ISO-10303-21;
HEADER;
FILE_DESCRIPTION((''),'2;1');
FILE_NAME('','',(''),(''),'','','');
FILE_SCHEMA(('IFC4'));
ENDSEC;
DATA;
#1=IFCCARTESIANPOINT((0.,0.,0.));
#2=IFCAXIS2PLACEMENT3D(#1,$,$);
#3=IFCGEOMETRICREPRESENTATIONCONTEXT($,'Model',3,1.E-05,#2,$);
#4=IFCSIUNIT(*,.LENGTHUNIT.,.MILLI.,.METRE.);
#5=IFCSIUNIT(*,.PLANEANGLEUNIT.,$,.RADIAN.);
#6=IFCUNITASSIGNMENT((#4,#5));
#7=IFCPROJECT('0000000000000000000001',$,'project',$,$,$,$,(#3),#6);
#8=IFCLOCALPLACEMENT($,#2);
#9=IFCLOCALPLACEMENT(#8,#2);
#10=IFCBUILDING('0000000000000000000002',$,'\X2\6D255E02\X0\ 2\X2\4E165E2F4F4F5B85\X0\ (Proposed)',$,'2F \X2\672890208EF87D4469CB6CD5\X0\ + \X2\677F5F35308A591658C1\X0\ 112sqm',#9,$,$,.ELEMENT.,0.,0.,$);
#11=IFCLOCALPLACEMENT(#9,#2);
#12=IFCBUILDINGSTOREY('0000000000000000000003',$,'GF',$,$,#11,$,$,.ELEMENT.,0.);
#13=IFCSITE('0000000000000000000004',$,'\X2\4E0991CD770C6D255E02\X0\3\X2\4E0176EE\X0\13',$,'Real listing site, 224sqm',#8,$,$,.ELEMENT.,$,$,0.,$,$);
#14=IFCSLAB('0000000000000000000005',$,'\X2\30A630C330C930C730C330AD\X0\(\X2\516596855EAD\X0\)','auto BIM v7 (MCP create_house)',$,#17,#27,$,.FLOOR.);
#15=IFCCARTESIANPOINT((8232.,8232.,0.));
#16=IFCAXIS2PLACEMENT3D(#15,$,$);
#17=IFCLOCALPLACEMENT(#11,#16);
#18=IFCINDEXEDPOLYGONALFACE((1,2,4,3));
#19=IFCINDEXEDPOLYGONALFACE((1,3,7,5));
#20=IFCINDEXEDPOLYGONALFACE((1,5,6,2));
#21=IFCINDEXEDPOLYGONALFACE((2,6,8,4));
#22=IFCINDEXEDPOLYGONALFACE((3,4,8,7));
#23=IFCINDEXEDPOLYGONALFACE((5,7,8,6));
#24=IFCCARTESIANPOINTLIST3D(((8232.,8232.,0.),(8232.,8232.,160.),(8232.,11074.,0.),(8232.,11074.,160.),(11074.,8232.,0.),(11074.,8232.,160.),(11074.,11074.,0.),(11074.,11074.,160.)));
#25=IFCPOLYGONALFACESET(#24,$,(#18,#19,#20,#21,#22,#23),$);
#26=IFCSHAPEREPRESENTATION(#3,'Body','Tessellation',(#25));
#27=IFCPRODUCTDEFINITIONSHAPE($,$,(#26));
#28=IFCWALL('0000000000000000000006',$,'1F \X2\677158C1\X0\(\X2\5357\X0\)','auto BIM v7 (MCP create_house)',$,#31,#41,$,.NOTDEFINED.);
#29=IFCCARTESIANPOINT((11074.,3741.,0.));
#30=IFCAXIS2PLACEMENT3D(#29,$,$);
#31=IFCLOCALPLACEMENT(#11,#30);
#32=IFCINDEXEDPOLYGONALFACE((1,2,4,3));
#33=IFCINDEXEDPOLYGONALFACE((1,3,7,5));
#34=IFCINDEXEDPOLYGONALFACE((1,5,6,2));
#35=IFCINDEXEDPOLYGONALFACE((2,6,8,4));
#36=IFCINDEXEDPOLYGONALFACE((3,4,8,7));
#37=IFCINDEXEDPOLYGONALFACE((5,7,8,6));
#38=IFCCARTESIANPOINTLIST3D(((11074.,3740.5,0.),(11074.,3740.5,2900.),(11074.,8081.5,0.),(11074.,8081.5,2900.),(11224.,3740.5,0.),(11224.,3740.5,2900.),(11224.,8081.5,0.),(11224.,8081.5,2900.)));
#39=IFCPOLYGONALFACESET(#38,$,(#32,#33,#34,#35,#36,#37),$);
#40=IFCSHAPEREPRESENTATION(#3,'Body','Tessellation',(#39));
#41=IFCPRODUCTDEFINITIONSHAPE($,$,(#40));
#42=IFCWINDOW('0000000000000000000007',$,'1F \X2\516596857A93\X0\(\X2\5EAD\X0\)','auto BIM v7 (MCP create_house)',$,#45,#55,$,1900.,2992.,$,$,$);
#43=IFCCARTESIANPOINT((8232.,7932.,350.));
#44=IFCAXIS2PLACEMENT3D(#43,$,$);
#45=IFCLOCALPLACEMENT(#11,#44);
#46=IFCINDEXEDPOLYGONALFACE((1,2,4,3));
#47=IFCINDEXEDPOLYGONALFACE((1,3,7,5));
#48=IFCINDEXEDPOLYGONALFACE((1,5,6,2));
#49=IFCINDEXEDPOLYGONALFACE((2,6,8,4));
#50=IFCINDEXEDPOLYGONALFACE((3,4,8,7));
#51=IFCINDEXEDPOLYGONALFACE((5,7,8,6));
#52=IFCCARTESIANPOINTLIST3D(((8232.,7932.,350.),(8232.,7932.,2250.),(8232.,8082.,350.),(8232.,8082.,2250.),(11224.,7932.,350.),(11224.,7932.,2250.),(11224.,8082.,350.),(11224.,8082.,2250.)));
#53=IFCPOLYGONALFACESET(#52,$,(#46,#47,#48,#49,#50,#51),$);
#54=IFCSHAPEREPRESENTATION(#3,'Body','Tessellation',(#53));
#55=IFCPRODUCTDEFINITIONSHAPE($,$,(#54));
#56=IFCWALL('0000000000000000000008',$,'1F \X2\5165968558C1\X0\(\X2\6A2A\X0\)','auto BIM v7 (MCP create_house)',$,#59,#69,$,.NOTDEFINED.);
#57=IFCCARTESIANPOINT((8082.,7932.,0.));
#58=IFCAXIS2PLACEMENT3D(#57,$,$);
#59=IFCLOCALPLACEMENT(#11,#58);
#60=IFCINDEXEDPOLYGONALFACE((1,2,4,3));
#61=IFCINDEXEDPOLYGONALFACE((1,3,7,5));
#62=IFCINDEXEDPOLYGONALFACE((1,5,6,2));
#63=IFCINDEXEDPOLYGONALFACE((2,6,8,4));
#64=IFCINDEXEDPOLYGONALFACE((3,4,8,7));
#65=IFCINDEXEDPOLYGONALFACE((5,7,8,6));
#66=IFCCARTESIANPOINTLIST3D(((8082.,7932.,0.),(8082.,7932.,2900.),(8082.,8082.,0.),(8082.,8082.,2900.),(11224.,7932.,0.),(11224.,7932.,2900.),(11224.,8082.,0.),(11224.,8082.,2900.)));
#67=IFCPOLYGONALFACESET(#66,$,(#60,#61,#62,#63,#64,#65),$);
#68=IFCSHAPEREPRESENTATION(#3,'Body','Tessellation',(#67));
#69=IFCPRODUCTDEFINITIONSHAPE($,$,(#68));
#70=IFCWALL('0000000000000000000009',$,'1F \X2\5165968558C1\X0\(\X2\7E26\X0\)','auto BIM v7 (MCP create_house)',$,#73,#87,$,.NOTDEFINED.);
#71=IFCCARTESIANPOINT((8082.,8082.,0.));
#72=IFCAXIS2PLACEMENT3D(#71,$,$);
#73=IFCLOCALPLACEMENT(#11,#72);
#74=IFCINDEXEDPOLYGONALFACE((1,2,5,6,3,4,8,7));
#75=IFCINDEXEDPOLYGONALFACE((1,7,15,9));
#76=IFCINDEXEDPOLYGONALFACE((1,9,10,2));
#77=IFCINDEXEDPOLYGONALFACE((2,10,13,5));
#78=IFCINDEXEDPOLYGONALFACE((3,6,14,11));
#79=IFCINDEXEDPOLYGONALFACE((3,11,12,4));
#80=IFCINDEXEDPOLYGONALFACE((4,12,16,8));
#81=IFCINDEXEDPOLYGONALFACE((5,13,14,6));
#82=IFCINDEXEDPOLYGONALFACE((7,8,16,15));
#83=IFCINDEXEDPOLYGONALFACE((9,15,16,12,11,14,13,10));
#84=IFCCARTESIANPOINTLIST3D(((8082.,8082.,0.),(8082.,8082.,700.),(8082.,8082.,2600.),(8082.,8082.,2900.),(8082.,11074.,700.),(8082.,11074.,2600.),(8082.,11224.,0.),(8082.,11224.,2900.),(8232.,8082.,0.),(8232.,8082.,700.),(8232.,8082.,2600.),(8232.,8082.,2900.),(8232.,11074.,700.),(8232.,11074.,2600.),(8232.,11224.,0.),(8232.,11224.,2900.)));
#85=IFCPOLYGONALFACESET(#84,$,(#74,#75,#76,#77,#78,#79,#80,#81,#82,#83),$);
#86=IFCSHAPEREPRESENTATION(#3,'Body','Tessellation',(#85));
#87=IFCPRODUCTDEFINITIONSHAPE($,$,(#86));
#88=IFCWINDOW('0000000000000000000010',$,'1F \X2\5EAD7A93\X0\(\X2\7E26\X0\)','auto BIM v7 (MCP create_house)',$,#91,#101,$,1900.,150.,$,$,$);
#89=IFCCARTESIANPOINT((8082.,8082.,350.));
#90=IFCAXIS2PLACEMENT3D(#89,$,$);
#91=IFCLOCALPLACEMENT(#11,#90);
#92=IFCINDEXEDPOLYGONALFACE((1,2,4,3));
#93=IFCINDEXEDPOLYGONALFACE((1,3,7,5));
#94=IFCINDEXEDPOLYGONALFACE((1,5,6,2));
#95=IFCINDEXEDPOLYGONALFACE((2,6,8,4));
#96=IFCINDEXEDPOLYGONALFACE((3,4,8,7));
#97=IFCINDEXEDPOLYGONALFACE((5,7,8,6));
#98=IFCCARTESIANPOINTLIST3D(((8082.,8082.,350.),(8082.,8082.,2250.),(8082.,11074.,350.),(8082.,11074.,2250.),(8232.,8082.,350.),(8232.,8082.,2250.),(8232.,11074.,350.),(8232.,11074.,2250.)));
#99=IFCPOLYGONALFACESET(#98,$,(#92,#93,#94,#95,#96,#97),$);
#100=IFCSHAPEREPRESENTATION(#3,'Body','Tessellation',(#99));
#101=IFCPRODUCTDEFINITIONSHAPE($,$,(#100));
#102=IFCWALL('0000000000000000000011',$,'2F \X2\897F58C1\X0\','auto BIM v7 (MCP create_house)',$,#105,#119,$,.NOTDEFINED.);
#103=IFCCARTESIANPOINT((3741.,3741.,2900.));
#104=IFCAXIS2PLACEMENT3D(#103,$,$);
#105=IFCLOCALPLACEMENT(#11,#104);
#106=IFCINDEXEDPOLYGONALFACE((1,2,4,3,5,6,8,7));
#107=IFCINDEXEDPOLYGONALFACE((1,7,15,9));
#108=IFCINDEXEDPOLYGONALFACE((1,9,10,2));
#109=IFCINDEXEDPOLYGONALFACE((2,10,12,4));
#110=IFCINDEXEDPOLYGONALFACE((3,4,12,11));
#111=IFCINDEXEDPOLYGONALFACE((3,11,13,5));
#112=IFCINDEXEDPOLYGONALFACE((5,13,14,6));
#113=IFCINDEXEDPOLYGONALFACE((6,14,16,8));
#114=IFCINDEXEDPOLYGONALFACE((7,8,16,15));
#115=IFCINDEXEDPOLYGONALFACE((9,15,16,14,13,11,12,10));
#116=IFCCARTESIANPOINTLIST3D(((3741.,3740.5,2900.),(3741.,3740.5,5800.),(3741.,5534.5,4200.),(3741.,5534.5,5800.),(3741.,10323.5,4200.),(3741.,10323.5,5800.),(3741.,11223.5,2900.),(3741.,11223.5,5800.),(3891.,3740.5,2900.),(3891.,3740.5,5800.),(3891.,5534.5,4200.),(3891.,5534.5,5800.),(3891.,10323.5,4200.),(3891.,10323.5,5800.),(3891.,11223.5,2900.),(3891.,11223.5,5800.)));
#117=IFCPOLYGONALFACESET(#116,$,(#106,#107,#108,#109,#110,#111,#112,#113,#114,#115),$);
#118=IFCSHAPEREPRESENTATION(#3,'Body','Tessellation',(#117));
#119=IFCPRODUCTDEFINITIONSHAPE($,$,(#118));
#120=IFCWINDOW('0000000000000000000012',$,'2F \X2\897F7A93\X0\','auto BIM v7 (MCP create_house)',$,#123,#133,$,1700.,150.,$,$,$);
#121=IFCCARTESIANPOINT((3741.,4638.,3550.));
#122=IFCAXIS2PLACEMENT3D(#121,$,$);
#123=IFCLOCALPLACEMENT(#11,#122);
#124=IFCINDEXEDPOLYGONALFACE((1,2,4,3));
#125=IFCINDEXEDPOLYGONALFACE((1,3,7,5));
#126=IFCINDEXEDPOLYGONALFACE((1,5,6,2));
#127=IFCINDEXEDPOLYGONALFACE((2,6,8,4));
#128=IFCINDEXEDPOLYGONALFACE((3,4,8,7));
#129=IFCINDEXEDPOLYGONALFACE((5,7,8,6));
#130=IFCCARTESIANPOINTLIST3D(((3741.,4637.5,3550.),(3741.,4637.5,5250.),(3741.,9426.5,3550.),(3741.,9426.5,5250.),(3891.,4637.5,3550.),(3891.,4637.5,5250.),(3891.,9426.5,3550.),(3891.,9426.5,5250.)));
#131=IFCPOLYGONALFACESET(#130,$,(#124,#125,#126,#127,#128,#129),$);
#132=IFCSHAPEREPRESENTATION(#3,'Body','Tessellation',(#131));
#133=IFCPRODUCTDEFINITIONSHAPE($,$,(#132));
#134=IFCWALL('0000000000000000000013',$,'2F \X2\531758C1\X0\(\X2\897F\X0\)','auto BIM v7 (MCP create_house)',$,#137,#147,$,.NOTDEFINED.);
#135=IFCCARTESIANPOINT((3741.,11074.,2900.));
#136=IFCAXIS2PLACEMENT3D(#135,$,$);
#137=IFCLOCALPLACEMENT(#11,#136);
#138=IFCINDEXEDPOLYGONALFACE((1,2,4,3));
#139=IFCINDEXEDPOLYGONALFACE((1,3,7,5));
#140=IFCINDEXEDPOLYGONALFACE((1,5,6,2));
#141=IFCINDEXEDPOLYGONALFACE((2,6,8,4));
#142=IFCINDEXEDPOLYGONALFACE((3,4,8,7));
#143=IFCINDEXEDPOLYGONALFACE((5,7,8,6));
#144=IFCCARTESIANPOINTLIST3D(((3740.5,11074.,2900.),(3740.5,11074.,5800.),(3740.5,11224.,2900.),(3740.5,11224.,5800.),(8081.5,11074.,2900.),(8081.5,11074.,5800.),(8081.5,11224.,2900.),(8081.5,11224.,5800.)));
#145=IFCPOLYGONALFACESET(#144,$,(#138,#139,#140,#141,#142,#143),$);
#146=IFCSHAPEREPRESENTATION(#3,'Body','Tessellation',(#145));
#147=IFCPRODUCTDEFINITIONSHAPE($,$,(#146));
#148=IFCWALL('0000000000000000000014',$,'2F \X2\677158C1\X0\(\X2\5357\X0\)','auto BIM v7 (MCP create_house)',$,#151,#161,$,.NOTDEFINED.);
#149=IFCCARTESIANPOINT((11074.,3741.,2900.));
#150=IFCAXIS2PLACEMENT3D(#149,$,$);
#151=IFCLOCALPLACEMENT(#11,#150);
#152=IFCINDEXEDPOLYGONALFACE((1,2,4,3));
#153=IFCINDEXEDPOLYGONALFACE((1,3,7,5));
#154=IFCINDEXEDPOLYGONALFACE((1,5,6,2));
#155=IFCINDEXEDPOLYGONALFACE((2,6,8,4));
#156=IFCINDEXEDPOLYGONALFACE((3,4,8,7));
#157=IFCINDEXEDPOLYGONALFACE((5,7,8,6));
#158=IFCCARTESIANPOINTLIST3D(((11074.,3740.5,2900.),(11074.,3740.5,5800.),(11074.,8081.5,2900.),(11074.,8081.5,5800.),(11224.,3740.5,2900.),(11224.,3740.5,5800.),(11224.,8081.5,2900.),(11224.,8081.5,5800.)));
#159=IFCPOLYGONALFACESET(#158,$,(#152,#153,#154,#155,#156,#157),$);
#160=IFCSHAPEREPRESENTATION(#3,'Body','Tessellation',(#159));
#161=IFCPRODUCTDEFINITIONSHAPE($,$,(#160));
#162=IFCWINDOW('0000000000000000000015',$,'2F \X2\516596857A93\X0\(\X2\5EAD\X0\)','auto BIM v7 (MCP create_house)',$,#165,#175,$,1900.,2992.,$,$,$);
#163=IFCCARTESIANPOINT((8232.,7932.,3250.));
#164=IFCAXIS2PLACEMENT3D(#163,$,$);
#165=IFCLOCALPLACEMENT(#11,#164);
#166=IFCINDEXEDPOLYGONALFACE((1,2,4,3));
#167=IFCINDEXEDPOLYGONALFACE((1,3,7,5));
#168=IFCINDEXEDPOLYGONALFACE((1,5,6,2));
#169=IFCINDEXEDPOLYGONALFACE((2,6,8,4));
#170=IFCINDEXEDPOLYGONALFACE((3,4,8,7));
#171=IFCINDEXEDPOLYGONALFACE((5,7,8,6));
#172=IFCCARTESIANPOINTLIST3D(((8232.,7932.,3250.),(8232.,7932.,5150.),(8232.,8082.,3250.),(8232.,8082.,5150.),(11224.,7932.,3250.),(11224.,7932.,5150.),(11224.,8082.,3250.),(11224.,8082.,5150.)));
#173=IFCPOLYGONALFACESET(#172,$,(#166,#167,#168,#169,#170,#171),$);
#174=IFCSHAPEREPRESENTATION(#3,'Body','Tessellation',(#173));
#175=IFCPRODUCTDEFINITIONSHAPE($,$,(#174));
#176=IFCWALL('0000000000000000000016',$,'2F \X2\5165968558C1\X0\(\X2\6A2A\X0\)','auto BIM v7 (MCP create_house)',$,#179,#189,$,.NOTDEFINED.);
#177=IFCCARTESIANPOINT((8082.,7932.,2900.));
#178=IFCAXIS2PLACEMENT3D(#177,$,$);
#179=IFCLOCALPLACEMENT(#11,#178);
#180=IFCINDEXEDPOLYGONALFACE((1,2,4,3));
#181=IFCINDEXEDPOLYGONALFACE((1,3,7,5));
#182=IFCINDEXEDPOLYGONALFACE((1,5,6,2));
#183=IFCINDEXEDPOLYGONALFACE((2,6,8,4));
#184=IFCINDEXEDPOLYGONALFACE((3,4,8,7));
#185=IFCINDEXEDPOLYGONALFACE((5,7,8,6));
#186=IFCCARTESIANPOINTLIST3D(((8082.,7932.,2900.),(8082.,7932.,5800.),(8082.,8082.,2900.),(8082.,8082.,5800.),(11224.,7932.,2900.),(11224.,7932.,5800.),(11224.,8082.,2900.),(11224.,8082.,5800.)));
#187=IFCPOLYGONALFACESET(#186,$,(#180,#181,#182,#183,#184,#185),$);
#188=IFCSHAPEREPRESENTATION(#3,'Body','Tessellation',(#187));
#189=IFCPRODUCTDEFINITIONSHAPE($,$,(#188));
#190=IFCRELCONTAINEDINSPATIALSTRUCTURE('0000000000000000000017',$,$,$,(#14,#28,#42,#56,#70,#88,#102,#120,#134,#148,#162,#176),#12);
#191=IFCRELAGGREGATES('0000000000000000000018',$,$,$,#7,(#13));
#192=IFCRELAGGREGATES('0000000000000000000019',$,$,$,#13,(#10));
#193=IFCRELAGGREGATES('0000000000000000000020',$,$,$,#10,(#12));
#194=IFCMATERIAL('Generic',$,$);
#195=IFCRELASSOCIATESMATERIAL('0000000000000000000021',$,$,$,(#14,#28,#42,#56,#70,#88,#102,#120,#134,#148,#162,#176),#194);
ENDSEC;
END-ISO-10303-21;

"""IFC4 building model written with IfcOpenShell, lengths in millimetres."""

from ifc_helpers import new_model, si_unit, frame, frame_2d, origin, place, context, project, spatial, rectangle, extrude, material, element, fill, save


model = new_model("IFC4")

# Units and contexts
model_context = context("Model", 3, precision=1e-05, world=origin())
ifc_project = project(units=[si_unit("LENGTHUNIT", "METRE", prefix="MILLI"), si_unit("PLANEANGLEUNIT", "RADIAN")], contexts=[model_context])

# Site, building, storey
site_placement = place(None, origin())
site = spatial("IfcSite", under=ifc_project, at=site_placement, Name="三重県津市3丁目13", ObjectType="Real listing site, 224sqm", CompositionType="ELEMENT", RefElevation=0.0)
building_placement = place(site_placement, origin())
building = spatial("IfcBuilding", under=site, at=building_placement, Name="津市 2世帯住宅 (Proposed)", ObjectType="2F 木造軸組構法 + 板張り外壁 112sqm", CompositionType="ELEMENT", ElevationOfRefHeight=0.0, ElevationOfTerrain=0.0)
storey_placement = place(building_placement, origin())
storey = spatial("IfcBuildingStorey", under=building, at=storey_placement, Name="GF", CompositionType="ELEMENT", Elevation=0.0)

# Slab
ifc_material = material(Name="Generic")
slab_placement = place(storey_placement, frame((8232.0, 8232.0, 0.0)))
element("IfcSlab", 1, at=slab_placement, inside=storey, material=ifc_material, Name="ウッドデッキ(入隅庭)", Description="auto BIM v7 (MCP create_house)", PredefinedType="FLOOR", context=model_context, shape_type="SweptSolid", body=[
    extrude(rectangle(XDim=2842.0, YDim=2842.0, at=frame_2d((1421.0, 1421.0))), frame((8232.0, 8232.0, 0.0)), (0.0, 0.0, 1.0), 160.0),
])

# Wall, opening, window
wall_1_placement = place(storey_placement, frame((11074.0, 3741.0, 0.0)))
wall_1 = element("IfcWall", 2, at=wall_1_placement, inside=storey, material=ifc_material, Name="1F 東壁(南)", Description="auto BIM v7 (MCP create_house)", PredefinedType="NOTDEFINED", context=model_context, shape_type="SweptSolid", body=[
    extrude(rectangle(XDim=150.0, YDim=4341.0, at=frame_2d((75.0, 2170.0))), frame((11074.0, 3741.0, 0.0)), (0.0, 0.0, 1.0), 2900.0),
])
opening_1_placement = place(storey_placement, frame((8232.0, 7932.0, 350.0)))
opening_1 = element("IfcOpeningElement", 3, at=opening_1_placement, cuts=wall_1, PredefinedType="NOTDEFINED", context=model_context, shape_type="SweptSolid", body=[
    extrude(rectangle(XDim=2992.0, YDim=150.0, at=frame_2d((1496.0, 75.0))), frame((8232.0, 7932.0, 350.0)), (0.0, 0.0, 1.0), 1900.0),
])
window_1_placement = place(storey_placement, frame((8232.0, 7932.0, 350.0)))
window_1 = element("IfcWindow", 4, at=window_1_placement, inside=storey, material=ifc_material, Name="1F 入隅窓(庭)", Description="auto BIM v7 (MCP create_house)", OverallHeight=1900.0, OverallWidth=2992.0, context=model_context, shape_type="SweptSolid", body=[
    extrude(rectangle(XDim=2992.0, YDim=150.0, at=frame_2d((1496.0, 75.0))), frame((8232.0, 7932.0, 350.0)), (0.0, 0.0, 1.0), 1900.0),
])
fill(opening_1, window_1)

# Wall
wall_2_placement = place(storey_placement, frame((8082.0, 7932.0, 0.0)))
element("IfcWall", 5, at=wall_2_placement, inside=storey, material=ifc_material, Name="1F 入隅壁(横)", Description="auto BIM v7 (MCP create_house)", PredefinedType="NOTDEFINED", context=model_context, shape_type="SweptSolid", body=[
    extrude(rectangle(XDim=3142.0, YDim=150.0, at=frame_2d((1571.0, 75.0))), frame((8082.0, 7932.0, 0.0)), (0.0, 0.0, 1.0), 2900.0),
])

# Wall, opening, window
wall_3_placement = place(storey_placement, frame((8082.0, 8082.0, 0.0)))
wall_3 = element("IfcWall", 6, at=wall_3_placement, inside=storey, material=ifc_material, Name="1F 入隅壁(縦)", Description="auto BIM v7 (MCP create_house)", PredefinedType="NOTDEFINED", context=model_context, shape_type="SweptSolid", body=[
    extrude(rectangle(XDim=150.0, YDim=3142.0, at=frame_2d((75.0, 1571.0))), frame((8082.0, 8082.0, 0.0)), (0.0, 0.0, 1.0), 2900.0),
])
opening_2_placement = place(storey_placement, frame((8082.0, 8082.0, 350.0)))
opening_2 = element("IfcOpeningElement", 7, at=opening_2_placement, cuts=wall_3, PredefinedType="NOTDEFINED", context=model_context, shape_type="SweptSolid", body=[
    extrude(rectangle(XDim=150.0, YDim=2992.0, at=frame_2d((75.0, 1496.0))), frame((8082.0, 8082.0, 350.0)), (0.0, 0.0, 1.0), 1900.0),
])
window_2_placement = place(storey_placement, frame((8082.0, 8082.0, 350.0)))
window_2 = element("IfcWindow", 8, at=window_2_placement, inside=storey, material=ifc_material, Name="1F 庭窓(縦)", Description="auto BIM v7 (MCP create_house)", OverallHeight=1900.0, OverallWidth=150.0, context=model_context, shape_type="SweptSolid", body=[
    extrude(rectangle(XDim=150.0, YDim=2992.0, at=frame_2d((75.0, 1496.0))), frame((8082.0, 8082.0, 350.0)), (0.0, 0.0, 1.0), 1900.0),
])
fill(opening_2, window_2)

# Wall, opening, window
wall_4_placement = place(storey_placement, frame((3741.0, 3741.0, 2900.0)))
wall_4 = element("IfcWall", 9, at=wall_4_placement, inside=storey, material=ifc_material, Name="2F 西壁", Description="auto BIM v7 (MCP create_house)", PredefinedType="NOTDEFINED", context=model_context, shape_type="SweptSolid", body=[
    extrude(rectangle(XDim=150.0, YDim=7483.0, at=frame_2d((75.0, 3741.0))), frame((3741.0, 3741.0, 2900.0)), (0.0, 0.0, 1.0), 2900.0),
])
opening_3_placement = place(storey_placement, frame((3741.0, 4638.0, 3550.0)))
opening_3 = element("IfcOpeningElement", 10, at=opening_3_placement, cuts=wall_4, PredefinedType="NOTDEFINED", context=model_context, shape_type="SweptSolid", body=[
    extrude(rectangle(XDim=150.0, YDim=4789.0, at=frame_2d((75.0, 2394.0))), frame((3741.0, 4638.0, 3550.0)), (0.0, 0.0, 1.0), 1700.0),
])
window_3_placement = place(storey_placement, frame((3741.0, 4638.0, 3550.0)))
window_3 = element("IfcWindow", 11, at=window_3_placement, inside=storey, material=ifc_material, Name="2F 西窓", Description="auto BIM v7 (MCP create_house)", OverallHeight=1700.0, OverallWidth=150.0, context=model_context, shape_type="SweptSolid", body=[
    extrude(rectangle(XDim=150.0, YDim=4789.0, at=frame_2d((75.0, 2394.0))), frame((3741.0, 4638.0, 3550.0)), (0.0, 0.0, 1.0), 1700.0),
])
fill(opening_3, window_3)

# Wall
wall_5_placement = place(storey_placement, frame((3741.0, 11074.0, 2900.0)))
element("IfcWall", 12, at=wall_5_placement, inside=storey, material=ifc_material, Name="2F 北壁(西)", Description="auto BIM v7 (MCP create_house)", PredefinedType="NOTDEFINED", context=model_context, shape_type="SweptSolid", body=[
    extrude(rectangle(XDim=4341.0, YDim=150.0, at=frame_2d((2170.0, 75.0))), frame((3741.0, 11074.0, 2900.0)), (0.0, 0.0, 1.0), 2900.0),
])

# Wall, opening, window
wall_6_placement = place(storey_placement, frame((11074.0, 3741.0, 2900.0)))
wall_6 = element("IfcWall", 13, at=wall_6_placement, inside=storey, material=ifc_material, Name="2F 東壁(南)", Description="auto BIM v7 (MCP create_house)", PredefinedType="NOTDEFINED", context=model_context, shape_type="SweptSolid", body=[
    extrude(rectangle(XDim=150.0, YDim=4341.0, at=frame_2d((75.0, 2170.0))), frame((11074.0, 3741.0, 2900.0)), (0.0, 0.0, 1.0), 2900.0),
])
opening_4_placement = place(storey_placement, frame((8232.0, 7932.0, 3250.0)))
opening_4 = element("IfcOpeningElement", 14, at=opening_4_placement, cuts=wall_6, PredefinedType="NOTDEFINED", context=model_context, shape_type="SweptSolid", body=[
    extrude(rectangle(XDim=2992.0, YDim=150.0, at=frame_2d((1496.0, 75.0))), frame((8232.0, 7932.0, 3250.0)), (0.0, 0.0, 1.0), 1900.0),
])
window_4_placement = place(storey_placement, frame((8232.0, 7932.0, 3250.0)))
window_4 = element("IfcWindow", 15, at=window_4_placement, inside=storey, material=ifc_material, Name="2F 入隅窓(庭)", Description="auto BIM v7 (MCP create_house)", OverallHeight=1900.0, OverallWidth=2992.0, context=model_context, shape_type="SweptSolid", body=[
    extrude(rectangle(XDim=2992.0, YDim=150.0, at=frame_2d((1496.0, 75.0))), frame((8232.0, 7932.0, 3250.0)), (0.0, 0.0, 1.0), 1900.0),
])
fill(opening_4, window_4)

# Wall
wall_7_placement = place(storey_placement, frame((8082.0, 7932.0, 2900.0)))
element("IfcWall", 16, at=wall_7_placement, inside=storey, material=ifc_material, Name="2F 入隅壁(横)", Description="auto BIM v7 (MCP create_house)", PredefinedType="NOTDEFINED", context=model_context, shape_type="SweptSolid", body=[
    extrude(rectangle(XDim=3142.0, YDim=150.0, at=frame_2d((1571.0, 75.0))), frame((8082.0, 7932.0, 2900.0)), (0.0, 0.0, 1.0), 2900.0),
])

save(model, "model.ifc")
